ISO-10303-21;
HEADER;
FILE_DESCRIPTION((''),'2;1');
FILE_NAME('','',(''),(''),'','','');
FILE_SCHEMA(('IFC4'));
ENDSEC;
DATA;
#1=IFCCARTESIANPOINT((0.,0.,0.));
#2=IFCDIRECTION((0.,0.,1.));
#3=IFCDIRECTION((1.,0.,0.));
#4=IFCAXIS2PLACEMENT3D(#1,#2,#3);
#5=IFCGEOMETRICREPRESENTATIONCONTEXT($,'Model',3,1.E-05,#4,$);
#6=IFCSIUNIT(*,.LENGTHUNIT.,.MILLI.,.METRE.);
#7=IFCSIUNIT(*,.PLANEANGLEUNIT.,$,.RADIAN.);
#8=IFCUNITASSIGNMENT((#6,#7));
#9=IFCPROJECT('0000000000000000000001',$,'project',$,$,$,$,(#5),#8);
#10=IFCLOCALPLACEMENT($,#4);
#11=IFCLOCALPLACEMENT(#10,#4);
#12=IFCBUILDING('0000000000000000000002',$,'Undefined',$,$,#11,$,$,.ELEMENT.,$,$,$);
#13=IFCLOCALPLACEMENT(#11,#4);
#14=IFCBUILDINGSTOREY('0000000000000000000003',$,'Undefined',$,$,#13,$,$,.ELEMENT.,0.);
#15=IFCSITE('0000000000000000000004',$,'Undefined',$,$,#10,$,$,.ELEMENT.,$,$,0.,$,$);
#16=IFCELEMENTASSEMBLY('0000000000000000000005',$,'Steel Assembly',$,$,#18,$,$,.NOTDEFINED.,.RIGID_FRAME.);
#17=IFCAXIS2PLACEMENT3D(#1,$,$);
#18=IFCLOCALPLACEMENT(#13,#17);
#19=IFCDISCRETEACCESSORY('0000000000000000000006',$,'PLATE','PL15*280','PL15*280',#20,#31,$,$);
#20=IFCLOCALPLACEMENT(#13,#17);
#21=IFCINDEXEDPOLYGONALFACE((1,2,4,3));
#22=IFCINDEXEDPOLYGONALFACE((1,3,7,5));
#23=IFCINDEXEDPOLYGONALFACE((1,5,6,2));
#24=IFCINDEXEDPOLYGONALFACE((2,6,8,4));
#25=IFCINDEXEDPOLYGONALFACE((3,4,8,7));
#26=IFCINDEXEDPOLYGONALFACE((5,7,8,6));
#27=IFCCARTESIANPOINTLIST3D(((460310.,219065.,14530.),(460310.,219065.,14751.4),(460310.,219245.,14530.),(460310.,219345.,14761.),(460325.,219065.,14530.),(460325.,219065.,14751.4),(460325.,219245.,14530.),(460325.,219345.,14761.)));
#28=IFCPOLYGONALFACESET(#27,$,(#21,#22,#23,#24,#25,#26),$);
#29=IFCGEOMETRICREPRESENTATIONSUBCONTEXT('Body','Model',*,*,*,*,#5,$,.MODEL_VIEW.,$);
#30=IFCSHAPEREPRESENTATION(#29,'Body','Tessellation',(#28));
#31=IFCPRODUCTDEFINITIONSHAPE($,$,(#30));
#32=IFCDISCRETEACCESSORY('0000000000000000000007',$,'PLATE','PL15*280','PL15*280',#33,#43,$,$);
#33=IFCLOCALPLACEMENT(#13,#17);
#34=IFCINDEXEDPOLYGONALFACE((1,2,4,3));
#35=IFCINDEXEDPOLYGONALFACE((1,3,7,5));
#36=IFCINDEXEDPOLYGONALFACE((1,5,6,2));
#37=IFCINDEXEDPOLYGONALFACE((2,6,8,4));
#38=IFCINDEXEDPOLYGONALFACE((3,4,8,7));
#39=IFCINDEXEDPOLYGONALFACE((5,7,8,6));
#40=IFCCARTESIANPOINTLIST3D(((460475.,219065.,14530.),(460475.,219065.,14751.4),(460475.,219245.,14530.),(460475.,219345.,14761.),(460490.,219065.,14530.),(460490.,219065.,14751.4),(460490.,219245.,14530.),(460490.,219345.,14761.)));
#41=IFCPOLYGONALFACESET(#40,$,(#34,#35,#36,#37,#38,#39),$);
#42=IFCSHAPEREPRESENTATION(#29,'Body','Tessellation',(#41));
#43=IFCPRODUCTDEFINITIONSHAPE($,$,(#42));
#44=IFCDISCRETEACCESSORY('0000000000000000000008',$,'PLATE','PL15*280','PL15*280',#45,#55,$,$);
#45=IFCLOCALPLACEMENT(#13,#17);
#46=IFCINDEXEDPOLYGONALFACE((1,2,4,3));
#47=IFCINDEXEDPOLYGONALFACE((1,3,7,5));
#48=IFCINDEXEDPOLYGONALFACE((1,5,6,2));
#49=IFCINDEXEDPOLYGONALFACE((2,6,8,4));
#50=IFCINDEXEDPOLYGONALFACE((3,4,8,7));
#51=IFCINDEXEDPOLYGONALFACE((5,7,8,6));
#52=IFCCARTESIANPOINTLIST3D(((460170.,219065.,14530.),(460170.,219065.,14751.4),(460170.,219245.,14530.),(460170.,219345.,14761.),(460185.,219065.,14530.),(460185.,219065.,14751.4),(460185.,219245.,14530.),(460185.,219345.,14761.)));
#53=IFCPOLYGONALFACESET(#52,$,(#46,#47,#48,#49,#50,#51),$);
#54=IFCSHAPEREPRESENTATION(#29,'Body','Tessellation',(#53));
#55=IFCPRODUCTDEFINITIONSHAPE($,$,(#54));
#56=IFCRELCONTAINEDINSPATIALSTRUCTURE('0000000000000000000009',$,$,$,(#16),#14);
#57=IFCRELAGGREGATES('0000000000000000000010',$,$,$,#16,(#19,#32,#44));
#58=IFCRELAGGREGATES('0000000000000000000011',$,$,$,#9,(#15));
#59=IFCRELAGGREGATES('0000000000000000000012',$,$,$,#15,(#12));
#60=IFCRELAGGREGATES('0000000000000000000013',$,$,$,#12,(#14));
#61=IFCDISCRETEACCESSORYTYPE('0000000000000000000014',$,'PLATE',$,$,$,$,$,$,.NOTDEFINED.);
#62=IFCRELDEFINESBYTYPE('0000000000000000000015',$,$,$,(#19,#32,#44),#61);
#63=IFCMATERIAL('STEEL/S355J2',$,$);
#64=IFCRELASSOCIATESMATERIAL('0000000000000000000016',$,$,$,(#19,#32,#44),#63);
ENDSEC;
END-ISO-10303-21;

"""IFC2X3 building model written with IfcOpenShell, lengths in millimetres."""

from ifc_helpers import new_model, si_unit, frame, origin_with_axes, place, context, subcontext, project, spatial, polyline, outline, extrude, material, type_object, element, aggregate, save


model = new_model("IFC2X3")

# Units and contexts
model_context = context("Model", 3, precision=1e-05, world=origin_with_axes())
body_context = subcontext(model_context, "Body", "Model", "MODEL_VIEW")
ifc_project = project(units=[si_unit("LENGTHUNIT", "METRE", prefix="MILLI"), si_unit("PLANEANGLEUNIT", "RADIAN")], contexts=[model_context])

# Site, building, storey
site_placement = place(None, origin_with_axes())
site = spatial("IfcSite", under=ifc_project, at=site_placement, Name="Undefined", CompositionType="ELEMENT", RefElevation=0.0)
building_placement = place(site_placement, origin_with_axes())
building = spatial("IfcBuilding", under=site, at=building_placement, Name="Undefined", CompositionType="ELEMENT")
storey_placement = place(building_placement, origin_with_axes())
storey = spatial("IfcBuildingStorey", under=building, at=storey_placement, Name="Undefined", CompositionType="ELEMENT", Elevation=0.0)

# Element assembly
assembly_1_placement = place(storey_placement, origin_with_axes())
assembly_1 = element("IfcElementAssembly", 1, at=assembly_1_placement, inside=storey, Name="Steel Assembly", AssemblyPlace="NOTDEFINED", PredefinedType="RIGID_FRAME")

# Discrete accessories
discrete_accessory_type_1 = type_object("IfcDiscreteAccessoryType", Name="PLATE")
ifc_material_1 = material(Name="STEEL/S355J2")
discrete_accessory_1_placement = place(assembly_1_placement, frame((460317.5, 219065.0, 14530.0), z_axis=(1.0, 0.0, 0.0), x_axis=(0.0, 1.0, 0.0)))
discrete_accessory_1 = element("IfcDiscreteAccessory", 2, at=discrete_accessory_1_placement, type_object=discrete_accessory_type_1, material=ifc_material_1, Name="PLATE", Description="PL15*280", ObjectType="PL15*280", context=body_context, shape_type="SweptSolid", body=[
    extrude(outline(polyline([(0.0, 0.0), (180.0, 0.0), (280.0, 231.0), (0.0, 221.4), (0.0, 0.0)])), frame((0.0, 0.0, -7.5), z_axis=(0.0, 0.0, 1.0), x_axis=(1.0, 0.0, 0.0)), (0.0, 0.0, 1.0), 15.0),
])
discrete_accessory_2_placement = place(assembly_1_placement, frame((460482.5, 219065.0, 14530.0), z_axis=(1.0, 0.0, 0.0), x_axis=(0.0, 1.0, 0.0)))
discrete_accessory_2 = element("IfcDiscreteAccessory", 3, at=discrete_accessory_2_placement, type_object=discrete_accessory_type_1, material=ifc_material_1, Name="PLATE", Description="PL15*280", ObjectType="PL15*280", context=body_context, shape_type="SweptSolid", body=[
    extrude(outline(polyline([(0.0, 0.0), (180.0, 0.0), (280.0, 231.0), (0.0, 221.4), (0.0, 0.0)])), frame((0.0, 0.0, -7.5), z_axis=(0.0, 0.0, 1.0), x_axis=(1.0, 0.0, 0.0)), (0.0, 0.0, 1.0), 15.0),
])
discrete_accessory_3_placement = place(assembly_1_placement, frame((460177.5, 219065.0, 14530.0), z_axis=(1.0, 0.0, 0.0), x_axis=(0.0, 1.0, 0.0)))
discrete_accessory_3 = element("IfcDiscreteAccessory", 4, at=discrete_accessory_3_placement, type_object=discrete_accessory_type_1, material=ifc_material_1, Name="PLATE", Description="PL15*280", ObjectType="PL15*280", context=body_context, shape_type="SweptSolid", body=[
    extrude(outline(polyline([(0.0, 0.0), (180.0, 0.0), (280.0, 231.0), (0.0, 221.4), (0.0, 0.0)])), frame((0.0, 0.0, -7.5), z_axis=(0.0, 0.0, 1.0), x_axis=(1.0, 0.0, 0.0)), (0.0, 0.0, 1.0), 15.0),
])
aggregate(assembly_1, [discrete_accessory_1, discrete_accessory_2, discrete_accessory_3])

save(model, "model.ifc")
